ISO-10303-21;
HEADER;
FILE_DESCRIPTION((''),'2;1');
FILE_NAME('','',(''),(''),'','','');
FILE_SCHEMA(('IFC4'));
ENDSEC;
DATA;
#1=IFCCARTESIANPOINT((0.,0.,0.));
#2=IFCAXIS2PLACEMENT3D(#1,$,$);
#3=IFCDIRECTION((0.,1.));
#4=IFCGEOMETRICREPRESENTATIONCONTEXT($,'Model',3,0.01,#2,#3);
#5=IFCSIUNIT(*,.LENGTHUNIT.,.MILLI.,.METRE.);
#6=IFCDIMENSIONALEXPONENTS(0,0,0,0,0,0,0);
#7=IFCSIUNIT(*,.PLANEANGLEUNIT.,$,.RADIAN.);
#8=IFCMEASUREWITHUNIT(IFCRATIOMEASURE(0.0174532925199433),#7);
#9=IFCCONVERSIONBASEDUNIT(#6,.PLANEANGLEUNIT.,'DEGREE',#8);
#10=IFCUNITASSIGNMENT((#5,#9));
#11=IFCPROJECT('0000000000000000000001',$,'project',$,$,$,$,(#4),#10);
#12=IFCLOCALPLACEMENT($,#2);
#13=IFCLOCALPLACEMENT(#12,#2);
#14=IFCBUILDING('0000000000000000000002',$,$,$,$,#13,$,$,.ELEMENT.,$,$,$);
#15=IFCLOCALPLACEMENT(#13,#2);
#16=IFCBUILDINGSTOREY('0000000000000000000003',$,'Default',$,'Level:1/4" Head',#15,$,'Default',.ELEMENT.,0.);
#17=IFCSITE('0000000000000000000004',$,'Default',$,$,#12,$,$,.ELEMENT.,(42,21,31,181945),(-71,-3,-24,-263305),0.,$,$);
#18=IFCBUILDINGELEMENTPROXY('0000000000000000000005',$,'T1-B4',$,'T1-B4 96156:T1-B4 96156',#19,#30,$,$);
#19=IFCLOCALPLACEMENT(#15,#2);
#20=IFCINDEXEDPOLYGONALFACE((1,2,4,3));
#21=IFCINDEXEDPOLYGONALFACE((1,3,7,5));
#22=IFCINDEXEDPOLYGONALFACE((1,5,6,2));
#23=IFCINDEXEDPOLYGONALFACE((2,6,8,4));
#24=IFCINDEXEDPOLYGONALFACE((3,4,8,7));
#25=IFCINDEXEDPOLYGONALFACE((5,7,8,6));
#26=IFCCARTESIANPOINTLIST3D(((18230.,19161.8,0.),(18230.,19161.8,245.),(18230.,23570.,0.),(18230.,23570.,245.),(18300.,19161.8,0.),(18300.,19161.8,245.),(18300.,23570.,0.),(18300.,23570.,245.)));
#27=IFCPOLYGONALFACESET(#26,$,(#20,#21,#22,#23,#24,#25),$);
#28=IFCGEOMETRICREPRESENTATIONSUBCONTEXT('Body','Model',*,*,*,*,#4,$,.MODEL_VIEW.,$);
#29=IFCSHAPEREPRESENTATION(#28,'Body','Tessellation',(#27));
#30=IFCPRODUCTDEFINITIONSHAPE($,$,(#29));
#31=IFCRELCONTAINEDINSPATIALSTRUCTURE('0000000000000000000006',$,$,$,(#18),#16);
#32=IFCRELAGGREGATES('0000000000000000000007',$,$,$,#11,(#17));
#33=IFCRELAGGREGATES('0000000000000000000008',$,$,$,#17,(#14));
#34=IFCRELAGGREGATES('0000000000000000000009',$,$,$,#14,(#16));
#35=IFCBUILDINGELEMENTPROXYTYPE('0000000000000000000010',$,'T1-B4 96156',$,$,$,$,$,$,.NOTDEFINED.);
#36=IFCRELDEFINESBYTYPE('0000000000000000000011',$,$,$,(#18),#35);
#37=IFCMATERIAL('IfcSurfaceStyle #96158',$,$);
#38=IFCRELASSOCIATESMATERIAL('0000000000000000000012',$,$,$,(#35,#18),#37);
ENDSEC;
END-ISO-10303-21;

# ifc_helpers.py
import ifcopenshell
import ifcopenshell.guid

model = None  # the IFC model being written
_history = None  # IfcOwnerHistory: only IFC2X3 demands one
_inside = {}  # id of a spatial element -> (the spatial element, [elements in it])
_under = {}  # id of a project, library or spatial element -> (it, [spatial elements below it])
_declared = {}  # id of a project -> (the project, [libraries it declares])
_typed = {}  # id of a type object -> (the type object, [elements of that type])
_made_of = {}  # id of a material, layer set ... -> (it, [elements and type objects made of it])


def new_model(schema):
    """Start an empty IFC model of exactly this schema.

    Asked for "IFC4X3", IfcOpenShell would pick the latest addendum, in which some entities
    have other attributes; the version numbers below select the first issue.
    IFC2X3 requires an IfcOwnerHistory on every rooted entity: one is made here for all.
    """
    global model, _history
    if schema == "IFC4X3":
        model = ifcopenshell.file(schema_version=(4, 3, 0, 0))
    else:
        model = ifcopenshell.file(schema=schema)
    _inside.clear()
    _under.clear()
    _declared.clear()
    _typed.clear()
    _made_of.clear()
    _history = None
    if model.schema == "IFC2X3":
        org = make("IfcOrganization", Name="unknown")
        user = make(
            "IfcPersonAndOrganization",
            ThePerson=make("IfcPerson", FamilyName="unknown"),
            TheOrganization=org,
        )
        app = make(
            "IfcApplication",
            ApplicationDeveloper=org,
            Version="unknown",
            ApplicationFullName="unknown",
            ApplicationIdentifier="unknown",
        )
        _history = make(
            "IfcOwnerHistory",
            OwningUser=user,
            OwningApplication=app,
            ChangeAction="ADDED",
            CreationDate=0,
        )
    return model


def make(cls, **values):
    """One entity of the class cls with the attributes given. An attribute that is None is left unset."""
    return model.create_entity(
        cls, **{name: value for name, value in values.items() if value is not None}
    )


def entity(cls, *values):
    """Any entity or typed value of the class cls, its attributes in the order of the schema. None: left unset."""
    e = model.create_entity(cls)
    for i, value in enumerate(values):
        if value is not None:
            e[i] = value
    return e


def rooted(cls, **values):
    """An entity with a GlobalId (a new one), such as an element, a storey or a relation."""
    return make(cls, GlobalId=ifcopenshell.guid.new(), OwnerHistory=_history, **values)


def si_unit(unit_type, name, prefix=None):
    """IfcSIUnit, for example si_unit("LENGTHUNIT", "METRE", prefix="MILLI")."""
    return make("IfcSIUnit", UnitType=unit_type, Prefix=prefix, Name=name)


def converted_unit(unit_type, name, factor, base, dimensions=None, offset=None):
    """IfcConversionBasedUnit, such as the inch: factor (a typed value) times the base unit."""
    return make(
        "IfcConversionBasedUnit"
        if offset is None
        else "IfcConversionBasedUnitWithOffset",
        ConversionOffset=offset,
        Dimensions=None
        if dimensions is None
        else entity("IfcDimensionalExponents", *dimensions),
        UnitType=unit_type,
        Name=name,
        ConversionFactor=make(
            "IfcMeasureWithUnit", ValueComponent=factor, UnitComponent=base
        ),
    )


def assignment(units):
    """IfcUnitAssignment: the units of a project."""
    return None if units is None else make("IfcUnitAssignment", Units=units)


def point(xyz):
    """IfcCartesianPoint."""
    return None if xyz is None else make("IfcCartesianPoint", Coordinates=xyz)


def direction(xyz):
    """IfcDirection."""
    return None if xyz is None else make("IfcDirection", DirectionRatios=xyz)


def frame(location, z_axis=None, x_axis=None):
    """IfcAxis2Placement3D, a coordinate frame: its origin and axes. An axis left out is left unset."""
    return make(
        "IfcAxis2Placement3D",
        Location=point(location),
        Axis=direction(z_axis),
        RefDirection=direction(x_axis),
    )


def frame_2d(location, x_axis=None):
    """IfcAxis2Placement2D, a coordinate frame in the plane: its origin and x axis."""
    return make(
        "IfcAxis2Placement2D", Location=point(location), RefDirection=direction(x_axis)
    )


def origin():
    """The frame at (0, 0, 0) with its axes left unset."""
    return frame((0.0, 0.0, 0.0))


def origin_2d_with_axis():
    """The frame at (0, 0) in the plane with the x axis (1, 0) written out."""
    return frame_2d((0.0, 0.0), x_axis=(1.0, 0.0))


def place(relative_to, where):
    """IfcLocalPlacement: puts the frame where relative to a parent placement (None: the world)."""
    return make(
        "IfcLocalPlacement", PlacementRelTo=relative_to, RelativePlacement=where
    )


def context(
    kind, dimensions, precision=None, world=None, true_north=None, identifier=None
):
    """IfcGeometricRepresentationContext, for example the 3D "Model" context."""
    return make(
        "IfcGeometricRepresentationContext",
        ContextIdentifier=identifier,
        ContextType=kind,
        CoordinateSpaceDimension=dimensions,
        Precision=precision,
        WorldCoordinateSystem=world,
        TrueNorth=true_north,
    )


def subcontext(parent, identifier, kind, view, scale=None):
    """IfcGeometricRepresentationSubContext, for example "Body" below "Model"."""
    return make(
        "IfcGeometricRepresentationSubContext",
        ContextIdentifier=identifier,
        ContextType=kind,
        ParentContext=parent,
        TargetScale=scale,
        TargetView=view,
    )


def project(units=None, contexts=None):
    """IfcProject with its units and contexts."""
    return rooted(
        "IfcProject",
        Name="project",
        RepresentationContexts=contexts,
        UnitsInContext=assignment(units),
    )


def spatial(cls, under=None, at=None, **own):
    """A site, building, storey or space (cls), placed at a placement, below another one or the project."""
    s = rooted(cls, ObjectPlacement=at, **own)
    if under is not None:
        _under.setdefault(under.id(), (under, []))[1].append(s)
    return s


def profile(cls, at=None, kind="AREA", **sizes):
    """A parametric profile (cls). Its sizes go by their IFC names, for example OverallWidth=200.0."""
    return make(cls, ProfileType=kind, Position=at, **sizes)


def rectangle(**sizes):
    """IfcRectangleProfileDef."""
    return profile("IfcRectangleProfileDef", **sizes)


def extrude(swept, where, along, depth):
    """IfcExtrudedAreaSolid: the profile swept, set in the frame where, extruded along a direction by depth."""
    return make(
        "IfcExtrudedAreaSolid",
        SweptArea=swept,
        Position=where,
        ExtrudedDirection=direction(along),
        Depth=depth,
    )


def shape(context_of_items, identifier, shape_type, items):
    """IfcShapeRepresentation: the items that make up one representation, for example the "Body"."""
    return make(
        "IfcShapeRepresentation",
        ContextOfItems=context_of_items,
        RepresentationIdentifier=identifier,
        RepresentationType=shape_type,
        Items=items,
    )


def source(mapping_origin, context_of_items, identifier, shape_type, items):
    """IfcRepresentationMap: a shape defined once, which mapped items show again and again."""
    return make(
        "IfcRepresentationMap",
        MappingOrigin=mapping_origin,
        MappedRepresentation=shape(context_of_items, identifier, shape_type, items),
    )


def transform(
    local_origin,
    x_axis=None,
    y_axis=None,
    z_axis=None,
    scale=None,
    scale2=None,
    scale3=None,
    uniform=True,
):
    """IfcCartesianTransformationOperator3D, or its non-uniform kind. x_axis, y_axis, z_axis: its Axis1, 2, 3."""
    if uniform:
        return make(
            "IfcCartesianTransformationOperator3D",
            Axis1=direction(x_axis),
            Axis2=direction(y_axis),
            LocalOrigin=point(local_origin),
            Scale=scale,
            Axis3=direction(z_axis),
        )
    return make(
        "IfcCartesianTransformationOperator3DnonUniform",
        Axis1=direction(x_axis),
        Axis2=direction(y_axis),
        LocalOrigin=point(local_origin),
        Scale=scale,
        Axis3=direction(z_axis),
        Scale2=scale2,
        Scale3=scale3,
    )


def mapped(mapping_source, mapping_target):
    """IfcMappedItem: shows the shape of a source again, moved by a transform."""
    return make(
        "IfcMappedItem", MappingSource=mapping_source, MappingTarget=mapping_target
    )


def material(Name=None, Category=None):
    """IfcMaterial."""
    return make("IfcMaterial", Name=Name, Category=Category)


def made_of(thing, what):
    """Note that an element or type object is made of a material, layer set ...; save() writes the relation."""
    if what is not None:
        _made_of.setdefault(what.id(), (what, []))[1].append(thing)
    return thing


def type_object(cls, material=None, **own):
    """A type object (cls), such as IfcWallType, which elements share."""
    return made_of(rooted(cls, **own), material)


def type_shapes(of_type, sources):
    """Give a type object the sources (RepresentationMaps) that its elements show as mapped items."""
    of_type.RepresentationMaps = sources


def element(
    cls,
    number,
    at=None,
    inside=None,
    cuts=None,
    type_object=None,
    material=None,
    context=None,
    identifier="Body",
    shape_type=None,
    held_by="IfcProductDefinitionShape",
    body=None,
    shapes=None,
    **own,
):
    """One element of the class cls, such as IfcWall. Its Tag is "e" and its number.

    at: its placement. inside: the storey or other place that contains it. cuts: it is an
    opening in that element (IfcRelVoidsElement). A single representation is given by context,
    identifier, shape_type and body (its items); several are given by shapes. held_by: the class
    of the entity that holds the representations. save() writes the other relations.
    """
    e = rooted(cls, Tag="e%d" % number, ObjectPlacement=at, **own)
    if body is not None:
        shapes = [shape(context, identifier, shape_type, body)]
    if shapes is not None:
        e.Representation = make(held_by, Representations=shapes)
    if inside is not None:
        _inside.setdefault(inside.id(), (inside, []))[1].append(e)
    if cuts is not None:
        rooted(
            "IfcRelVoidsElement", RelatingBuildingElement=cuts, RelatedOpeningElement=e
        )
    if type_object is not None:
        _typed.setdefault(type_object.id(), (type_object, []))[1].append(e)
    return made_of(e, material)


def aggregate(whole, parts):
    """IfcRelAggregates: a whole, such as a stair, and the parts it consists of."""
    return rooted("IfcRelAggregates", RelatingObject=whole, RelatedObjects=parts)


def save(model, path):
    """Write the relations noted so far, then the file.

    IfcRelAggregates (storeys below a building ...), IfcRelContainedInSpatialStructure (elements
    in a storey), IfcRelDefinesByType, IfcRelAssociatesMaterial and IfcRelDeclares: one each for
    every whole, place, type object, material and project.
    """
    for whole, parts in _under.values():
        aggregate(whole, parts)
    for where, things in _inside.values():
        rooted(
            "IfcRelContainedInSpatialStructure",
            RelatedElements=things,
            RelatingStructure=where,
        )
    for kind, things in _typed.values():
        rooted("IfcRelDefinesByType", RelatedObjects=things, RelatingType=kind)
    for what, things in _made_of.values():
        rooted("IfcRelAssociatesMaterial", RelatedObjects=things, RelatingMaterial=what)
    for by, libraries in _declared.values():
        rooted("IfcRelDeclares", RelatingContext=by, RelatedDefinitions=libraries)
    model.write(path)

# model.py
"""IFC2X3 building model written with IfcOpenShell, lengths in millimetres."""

from ifc_helpers import new_model, entity, si_unit, converted_unit, direction, frame, origin, origin_2d_with_axis, place, context, subcontext, project, spatial, rectangle, extrude, source, transform, mapped, material, type_object, type_shapes, element, save


model = new_model("IFC2X3")

# Units and contexts
model_context = context("Model", 3, precision=0.01, world=origin(), true_north=direction((0.0, 1.0)))
body_context = subcontext(model_context, "Body", "Model", "MODEL_VIEW")
ifc_project = project(units=[si_unit("LENGTHUNIT", "METRE", prefix="MILLI"), converted_unit("PLANEANGLEUNIT", "DEGREE", entity("IfcRatioMeasure", 0.0174532925199433), si_unit("PLANEANGLEUNIT", "RADIAN"), dimensions=[0, 0, 0, 0, 0, 0, 0])], contexts=[model_context])

# Site, building, storey
site_placement = place(None, origin())
site = spatial("IfcSite", under=ifc_project, at=site_placement, Name="Default", CompositionType="ELEMENT", RefLatitude=(42, 21, 31, 181945), RefLongitude=(-71, -3, -24, -263305), RefElevation=0.0)
building_placement = place(site_placement, origin())
building = spatial("IfcBuilding", under=site, at=building_placement, CompositionType="ELEMENT")
storey_placement = place(building_placement, origin())
storey = spatial("IfcBuildingStorey", under=building, at=storey_placement, Name="Default", ObjectType="Level:1/4\" Head", LongName="Default", CompositionType="ELEMENT", Elevation=0.0)

# Building element proxy
ifc_material_1 = material(Name="IfcSurfaceStyle #96158")
building_element_proxy_type_1 = type_object("IfcBuildingElementProxyType", Name="T1-B4 96156", PredefinedType="NOTDEFINED", material=ifc_material_1)
shared_shape_1 = source(origin(), body_context, "Body", "SweptSolid", [
    extrude(rectangle(XDim=4408.2, YDim=245.0, at=origin_2d_with_axis()), frame((2204.1, 122.5, 0.0), z_axis=(0.0, 0.0, 1.0), x_axis=(-1.0, 0.0, 0.0)), (0.0, 0.0, 1.0), 70.0),
])
type_shapes(building_element_proxy_type_1, [shared_shape_1])
proxy_1_placement = place(building_placement, frame((18300.0, 19161.8, 245.0), z_axis=(-1.0, 0.0, 0.0), x_axis=(0.0, 1.0, 0.0)))
element("IfcBuildingElementProxy", 1, at=proxy_1_placement, inside=storey, type_object=building_element_proxy_type_1, material=ifc_material_1, Name="T1-B4", ObjectType="T1-B4 96156:T1-B4 96156", context=body_context, shape_type="MappedRepresentation", body=[
    mapped(shared_shape_1, transform((0.0, 0.0, 0.0), scale=1.0)),
])

save(model, "model.ifc")
